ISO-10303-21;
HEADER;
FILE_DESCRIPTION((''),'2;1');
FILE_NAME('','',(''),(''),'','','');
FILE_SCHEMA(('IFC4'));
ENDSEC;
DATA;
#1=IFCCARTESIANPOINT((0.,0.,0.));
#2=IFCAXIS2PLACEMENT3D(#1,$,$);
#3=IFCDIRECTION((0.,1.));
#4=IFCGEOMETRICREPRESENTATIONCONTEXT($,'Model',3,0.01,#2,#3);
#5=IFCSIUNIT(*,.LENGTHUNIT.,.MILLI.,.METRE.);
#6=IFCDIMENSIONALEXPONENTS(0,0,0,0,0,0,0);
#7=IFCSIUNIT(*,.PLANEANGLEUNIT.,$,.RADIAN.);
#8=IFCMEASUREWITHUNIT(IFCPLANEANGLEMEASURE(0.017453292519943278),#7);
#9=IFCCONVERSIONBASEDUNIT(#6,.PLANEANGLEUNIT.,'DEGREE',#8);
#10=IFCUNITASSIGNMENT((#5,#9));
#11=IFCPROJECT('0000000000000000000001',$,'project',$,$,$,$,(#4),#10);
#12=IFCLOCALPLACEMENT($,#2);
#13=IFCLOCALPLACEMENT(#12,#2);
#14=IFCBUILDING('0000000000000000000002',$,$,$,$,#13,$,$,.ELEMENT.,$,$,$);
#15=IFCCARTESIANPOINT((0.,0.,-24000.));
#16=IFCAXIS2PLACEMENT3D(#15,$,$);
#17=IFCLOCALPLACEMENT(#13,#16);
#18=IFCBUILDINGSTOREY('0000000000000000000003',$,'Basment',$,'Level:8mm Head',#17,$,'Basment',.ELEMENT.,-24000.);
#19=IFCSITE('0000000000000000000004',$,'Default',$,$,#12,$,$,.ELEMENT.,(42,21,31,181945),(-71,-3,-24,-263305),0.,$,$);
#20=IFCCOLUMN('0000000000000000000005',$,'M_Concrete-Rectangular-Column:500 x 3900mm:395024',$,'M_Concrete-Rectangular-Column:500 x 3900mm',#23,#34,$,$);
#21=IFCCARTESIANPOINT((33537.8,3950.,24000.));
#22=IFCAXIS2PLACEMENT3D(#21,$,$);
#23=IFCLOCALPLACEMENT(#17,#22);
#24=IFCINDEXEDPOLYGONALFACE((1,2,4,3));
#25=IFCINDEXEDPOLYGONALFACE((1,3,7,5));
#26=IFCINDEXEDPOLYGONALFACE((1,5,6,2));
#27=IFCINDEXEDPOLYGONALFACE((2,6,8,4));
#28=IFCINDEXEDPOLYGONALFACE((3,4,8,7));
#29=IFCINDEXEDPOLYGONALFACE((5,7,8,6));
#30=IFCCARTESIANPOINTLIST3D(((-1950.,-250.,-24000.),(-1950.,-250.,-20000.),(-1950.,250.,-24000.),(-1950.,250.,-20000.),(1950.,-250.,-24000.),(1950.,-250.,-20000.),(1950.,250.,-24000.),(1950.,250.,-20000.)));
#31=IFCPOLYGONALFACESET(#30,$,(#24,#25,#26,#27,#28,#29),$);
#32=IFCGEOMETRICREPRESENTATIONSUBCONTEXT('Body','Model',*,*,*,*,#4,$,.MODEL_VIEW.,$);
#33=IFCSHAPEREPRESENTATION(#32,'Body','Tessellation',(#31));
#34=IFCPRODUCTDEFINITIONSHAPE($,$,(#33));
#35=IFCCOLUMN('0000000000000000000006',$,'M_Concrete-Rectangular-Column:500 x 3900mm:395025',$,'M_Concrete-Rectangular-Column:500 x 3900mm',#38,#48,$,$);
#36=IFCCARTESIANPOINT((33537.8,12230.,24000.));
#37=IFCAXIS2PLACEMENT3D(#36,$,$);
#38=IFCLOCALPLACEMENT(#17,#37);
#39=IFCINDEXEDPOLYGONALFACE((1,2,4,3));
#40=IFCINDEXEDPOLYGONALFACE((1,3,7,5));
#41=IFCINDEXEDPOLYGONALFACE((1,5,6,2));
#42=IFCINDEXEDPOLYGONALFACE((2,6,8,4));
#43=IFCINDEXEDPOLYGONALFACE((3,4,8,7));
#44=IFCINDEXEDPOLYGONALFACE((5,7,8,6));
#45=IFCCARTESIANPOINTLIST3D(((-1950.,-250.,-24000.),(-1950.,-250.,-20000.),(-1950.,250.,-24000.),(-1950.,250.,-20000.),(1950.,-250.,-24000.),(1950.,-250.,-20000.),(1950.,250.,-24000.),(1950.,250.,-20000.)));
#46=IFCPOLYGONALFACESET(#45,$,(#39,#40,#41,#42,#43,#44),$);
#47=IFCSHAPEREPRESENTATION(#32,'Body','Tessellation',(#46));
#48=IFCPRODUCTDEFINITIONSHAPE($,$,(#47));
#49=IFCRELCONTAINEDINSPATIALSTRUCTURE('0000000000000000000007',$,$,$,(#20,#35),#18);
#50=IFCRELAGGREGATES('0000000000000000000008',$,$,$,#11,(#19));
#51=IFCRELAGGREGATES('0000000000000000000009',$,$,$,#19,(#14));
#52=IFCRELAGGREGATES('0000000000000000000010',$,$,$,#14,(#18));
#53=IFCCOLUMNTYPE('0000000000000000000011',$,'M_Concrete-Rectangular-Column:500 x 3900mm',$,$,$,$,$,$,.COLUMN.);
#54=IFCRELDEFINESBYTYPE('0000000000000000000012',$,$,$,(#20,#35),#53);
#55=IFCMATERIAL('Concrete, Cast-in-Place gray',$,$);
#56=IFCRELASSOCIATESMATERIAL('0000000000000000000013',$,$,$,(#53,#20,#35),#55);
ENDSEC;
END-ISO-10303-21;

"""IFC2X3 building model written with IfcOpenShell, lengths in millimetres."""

from ifc_helpers import new_model, entity, si_unit, converted_unit, direction, frame, origin, origin_2d_with_axis, place, context, subcontext, project, spatial, rectangle, extrude, source, transform, mapped, material, type_object, type_shapes, element, save


model = new_model("IFC2X3")

# Units and contexts
model_context = context("Model", 3, precision=0.01, world=origin(), true_north=direction((0.0, 1.0)))
body_context = subcontext(model_context, "Body", "Model", "MODEL_VIEW")
ifc_project = project(units=[si_unit("LENGTHUNIT", "METRE", prefix="MILLI"), converted_unit("PLANEANGLEUNIT", "DEGREE", entity("IfcPlaneAngleMeasure", 0.017453292519943278), si_unit("PLANEANGLEUNIT", "RADIAN"), dimensions=[0, 0, 0, 0, 0, 0, 0])], contexts=[model_context])

# Site, building, storey
site_placement = place(None, origin())
site = spatial("IfcSite", under=ifc_project, at=site_placement, Name="Default", CompositionType="ELEMENT", RefLatitude=(42, 21, 31, 181945), RefLongitude=(-71, -3, -24, -263305), RefElevation=0.0)
building_placement = place(site_placement, origin())
building = spatial("IfcBuilding", under=site, at=building_placement, CompositionType="ELEMENT")
storey_placement = place(building_placement, frame((0.0, 0.0, -24000.0)))
storey = spatial("IfcBuildingStorey", under=building, at=storey_placement, Name="Basment", ObjectType="Level:8mm Head", LongName="Basment", CompositionType="ELEMENT", Elevation=-24000.0)

# Columns
ifc_material_1 = material(Name="Concrete, Cast-in-Place gray")
column_type = type_object("IfcColumnType", Name="M_Concrete-Rectangular-Column:500 x 3900mm", PredefinedType="COLUMN", material=ifc_material_1)
shared_shape = source(origin(), body_context, "Body", "SweptSolid", [
    extrude(rectangle(XDim=3900.0, YDim=500.0, at=origin_2d_with_axis()), frame((0.0, 0.0, -24000.0), z_axis=(0.0, 0.0, 1.0), x_axis=(-1.0, 0.0, 0.0)), (0.0, 0.0, 1.0), 4000.0),
])
type_shapes(column_type, [shared_shape])
for number, where, name in (
    (1, (33537.8, 3950.0, 24000.0), "M_Concrete-Rectangular-Column:500 x 3900mm:395024"),
    (2, (33537.8, 12230.0, 24000.0), "M_Concrete-Rectangular-Column:500 x 3900mm:395025"),
):
    element("IfcColumn", number, at=place(storey_placement, frame(where)), inside=storey, type_object=column_type, material=ifc_material_1, Name=name, ObjectType="M_Concrete-Rectangular-Column:500 x 3900mm", context=body_context, shape_type="MappedRepresentation", body=[
        mapped(shared_shape, transform((0.0, 0.0, 0.0), scale=1.0)),
    ])

save(model, "model.ifc")
